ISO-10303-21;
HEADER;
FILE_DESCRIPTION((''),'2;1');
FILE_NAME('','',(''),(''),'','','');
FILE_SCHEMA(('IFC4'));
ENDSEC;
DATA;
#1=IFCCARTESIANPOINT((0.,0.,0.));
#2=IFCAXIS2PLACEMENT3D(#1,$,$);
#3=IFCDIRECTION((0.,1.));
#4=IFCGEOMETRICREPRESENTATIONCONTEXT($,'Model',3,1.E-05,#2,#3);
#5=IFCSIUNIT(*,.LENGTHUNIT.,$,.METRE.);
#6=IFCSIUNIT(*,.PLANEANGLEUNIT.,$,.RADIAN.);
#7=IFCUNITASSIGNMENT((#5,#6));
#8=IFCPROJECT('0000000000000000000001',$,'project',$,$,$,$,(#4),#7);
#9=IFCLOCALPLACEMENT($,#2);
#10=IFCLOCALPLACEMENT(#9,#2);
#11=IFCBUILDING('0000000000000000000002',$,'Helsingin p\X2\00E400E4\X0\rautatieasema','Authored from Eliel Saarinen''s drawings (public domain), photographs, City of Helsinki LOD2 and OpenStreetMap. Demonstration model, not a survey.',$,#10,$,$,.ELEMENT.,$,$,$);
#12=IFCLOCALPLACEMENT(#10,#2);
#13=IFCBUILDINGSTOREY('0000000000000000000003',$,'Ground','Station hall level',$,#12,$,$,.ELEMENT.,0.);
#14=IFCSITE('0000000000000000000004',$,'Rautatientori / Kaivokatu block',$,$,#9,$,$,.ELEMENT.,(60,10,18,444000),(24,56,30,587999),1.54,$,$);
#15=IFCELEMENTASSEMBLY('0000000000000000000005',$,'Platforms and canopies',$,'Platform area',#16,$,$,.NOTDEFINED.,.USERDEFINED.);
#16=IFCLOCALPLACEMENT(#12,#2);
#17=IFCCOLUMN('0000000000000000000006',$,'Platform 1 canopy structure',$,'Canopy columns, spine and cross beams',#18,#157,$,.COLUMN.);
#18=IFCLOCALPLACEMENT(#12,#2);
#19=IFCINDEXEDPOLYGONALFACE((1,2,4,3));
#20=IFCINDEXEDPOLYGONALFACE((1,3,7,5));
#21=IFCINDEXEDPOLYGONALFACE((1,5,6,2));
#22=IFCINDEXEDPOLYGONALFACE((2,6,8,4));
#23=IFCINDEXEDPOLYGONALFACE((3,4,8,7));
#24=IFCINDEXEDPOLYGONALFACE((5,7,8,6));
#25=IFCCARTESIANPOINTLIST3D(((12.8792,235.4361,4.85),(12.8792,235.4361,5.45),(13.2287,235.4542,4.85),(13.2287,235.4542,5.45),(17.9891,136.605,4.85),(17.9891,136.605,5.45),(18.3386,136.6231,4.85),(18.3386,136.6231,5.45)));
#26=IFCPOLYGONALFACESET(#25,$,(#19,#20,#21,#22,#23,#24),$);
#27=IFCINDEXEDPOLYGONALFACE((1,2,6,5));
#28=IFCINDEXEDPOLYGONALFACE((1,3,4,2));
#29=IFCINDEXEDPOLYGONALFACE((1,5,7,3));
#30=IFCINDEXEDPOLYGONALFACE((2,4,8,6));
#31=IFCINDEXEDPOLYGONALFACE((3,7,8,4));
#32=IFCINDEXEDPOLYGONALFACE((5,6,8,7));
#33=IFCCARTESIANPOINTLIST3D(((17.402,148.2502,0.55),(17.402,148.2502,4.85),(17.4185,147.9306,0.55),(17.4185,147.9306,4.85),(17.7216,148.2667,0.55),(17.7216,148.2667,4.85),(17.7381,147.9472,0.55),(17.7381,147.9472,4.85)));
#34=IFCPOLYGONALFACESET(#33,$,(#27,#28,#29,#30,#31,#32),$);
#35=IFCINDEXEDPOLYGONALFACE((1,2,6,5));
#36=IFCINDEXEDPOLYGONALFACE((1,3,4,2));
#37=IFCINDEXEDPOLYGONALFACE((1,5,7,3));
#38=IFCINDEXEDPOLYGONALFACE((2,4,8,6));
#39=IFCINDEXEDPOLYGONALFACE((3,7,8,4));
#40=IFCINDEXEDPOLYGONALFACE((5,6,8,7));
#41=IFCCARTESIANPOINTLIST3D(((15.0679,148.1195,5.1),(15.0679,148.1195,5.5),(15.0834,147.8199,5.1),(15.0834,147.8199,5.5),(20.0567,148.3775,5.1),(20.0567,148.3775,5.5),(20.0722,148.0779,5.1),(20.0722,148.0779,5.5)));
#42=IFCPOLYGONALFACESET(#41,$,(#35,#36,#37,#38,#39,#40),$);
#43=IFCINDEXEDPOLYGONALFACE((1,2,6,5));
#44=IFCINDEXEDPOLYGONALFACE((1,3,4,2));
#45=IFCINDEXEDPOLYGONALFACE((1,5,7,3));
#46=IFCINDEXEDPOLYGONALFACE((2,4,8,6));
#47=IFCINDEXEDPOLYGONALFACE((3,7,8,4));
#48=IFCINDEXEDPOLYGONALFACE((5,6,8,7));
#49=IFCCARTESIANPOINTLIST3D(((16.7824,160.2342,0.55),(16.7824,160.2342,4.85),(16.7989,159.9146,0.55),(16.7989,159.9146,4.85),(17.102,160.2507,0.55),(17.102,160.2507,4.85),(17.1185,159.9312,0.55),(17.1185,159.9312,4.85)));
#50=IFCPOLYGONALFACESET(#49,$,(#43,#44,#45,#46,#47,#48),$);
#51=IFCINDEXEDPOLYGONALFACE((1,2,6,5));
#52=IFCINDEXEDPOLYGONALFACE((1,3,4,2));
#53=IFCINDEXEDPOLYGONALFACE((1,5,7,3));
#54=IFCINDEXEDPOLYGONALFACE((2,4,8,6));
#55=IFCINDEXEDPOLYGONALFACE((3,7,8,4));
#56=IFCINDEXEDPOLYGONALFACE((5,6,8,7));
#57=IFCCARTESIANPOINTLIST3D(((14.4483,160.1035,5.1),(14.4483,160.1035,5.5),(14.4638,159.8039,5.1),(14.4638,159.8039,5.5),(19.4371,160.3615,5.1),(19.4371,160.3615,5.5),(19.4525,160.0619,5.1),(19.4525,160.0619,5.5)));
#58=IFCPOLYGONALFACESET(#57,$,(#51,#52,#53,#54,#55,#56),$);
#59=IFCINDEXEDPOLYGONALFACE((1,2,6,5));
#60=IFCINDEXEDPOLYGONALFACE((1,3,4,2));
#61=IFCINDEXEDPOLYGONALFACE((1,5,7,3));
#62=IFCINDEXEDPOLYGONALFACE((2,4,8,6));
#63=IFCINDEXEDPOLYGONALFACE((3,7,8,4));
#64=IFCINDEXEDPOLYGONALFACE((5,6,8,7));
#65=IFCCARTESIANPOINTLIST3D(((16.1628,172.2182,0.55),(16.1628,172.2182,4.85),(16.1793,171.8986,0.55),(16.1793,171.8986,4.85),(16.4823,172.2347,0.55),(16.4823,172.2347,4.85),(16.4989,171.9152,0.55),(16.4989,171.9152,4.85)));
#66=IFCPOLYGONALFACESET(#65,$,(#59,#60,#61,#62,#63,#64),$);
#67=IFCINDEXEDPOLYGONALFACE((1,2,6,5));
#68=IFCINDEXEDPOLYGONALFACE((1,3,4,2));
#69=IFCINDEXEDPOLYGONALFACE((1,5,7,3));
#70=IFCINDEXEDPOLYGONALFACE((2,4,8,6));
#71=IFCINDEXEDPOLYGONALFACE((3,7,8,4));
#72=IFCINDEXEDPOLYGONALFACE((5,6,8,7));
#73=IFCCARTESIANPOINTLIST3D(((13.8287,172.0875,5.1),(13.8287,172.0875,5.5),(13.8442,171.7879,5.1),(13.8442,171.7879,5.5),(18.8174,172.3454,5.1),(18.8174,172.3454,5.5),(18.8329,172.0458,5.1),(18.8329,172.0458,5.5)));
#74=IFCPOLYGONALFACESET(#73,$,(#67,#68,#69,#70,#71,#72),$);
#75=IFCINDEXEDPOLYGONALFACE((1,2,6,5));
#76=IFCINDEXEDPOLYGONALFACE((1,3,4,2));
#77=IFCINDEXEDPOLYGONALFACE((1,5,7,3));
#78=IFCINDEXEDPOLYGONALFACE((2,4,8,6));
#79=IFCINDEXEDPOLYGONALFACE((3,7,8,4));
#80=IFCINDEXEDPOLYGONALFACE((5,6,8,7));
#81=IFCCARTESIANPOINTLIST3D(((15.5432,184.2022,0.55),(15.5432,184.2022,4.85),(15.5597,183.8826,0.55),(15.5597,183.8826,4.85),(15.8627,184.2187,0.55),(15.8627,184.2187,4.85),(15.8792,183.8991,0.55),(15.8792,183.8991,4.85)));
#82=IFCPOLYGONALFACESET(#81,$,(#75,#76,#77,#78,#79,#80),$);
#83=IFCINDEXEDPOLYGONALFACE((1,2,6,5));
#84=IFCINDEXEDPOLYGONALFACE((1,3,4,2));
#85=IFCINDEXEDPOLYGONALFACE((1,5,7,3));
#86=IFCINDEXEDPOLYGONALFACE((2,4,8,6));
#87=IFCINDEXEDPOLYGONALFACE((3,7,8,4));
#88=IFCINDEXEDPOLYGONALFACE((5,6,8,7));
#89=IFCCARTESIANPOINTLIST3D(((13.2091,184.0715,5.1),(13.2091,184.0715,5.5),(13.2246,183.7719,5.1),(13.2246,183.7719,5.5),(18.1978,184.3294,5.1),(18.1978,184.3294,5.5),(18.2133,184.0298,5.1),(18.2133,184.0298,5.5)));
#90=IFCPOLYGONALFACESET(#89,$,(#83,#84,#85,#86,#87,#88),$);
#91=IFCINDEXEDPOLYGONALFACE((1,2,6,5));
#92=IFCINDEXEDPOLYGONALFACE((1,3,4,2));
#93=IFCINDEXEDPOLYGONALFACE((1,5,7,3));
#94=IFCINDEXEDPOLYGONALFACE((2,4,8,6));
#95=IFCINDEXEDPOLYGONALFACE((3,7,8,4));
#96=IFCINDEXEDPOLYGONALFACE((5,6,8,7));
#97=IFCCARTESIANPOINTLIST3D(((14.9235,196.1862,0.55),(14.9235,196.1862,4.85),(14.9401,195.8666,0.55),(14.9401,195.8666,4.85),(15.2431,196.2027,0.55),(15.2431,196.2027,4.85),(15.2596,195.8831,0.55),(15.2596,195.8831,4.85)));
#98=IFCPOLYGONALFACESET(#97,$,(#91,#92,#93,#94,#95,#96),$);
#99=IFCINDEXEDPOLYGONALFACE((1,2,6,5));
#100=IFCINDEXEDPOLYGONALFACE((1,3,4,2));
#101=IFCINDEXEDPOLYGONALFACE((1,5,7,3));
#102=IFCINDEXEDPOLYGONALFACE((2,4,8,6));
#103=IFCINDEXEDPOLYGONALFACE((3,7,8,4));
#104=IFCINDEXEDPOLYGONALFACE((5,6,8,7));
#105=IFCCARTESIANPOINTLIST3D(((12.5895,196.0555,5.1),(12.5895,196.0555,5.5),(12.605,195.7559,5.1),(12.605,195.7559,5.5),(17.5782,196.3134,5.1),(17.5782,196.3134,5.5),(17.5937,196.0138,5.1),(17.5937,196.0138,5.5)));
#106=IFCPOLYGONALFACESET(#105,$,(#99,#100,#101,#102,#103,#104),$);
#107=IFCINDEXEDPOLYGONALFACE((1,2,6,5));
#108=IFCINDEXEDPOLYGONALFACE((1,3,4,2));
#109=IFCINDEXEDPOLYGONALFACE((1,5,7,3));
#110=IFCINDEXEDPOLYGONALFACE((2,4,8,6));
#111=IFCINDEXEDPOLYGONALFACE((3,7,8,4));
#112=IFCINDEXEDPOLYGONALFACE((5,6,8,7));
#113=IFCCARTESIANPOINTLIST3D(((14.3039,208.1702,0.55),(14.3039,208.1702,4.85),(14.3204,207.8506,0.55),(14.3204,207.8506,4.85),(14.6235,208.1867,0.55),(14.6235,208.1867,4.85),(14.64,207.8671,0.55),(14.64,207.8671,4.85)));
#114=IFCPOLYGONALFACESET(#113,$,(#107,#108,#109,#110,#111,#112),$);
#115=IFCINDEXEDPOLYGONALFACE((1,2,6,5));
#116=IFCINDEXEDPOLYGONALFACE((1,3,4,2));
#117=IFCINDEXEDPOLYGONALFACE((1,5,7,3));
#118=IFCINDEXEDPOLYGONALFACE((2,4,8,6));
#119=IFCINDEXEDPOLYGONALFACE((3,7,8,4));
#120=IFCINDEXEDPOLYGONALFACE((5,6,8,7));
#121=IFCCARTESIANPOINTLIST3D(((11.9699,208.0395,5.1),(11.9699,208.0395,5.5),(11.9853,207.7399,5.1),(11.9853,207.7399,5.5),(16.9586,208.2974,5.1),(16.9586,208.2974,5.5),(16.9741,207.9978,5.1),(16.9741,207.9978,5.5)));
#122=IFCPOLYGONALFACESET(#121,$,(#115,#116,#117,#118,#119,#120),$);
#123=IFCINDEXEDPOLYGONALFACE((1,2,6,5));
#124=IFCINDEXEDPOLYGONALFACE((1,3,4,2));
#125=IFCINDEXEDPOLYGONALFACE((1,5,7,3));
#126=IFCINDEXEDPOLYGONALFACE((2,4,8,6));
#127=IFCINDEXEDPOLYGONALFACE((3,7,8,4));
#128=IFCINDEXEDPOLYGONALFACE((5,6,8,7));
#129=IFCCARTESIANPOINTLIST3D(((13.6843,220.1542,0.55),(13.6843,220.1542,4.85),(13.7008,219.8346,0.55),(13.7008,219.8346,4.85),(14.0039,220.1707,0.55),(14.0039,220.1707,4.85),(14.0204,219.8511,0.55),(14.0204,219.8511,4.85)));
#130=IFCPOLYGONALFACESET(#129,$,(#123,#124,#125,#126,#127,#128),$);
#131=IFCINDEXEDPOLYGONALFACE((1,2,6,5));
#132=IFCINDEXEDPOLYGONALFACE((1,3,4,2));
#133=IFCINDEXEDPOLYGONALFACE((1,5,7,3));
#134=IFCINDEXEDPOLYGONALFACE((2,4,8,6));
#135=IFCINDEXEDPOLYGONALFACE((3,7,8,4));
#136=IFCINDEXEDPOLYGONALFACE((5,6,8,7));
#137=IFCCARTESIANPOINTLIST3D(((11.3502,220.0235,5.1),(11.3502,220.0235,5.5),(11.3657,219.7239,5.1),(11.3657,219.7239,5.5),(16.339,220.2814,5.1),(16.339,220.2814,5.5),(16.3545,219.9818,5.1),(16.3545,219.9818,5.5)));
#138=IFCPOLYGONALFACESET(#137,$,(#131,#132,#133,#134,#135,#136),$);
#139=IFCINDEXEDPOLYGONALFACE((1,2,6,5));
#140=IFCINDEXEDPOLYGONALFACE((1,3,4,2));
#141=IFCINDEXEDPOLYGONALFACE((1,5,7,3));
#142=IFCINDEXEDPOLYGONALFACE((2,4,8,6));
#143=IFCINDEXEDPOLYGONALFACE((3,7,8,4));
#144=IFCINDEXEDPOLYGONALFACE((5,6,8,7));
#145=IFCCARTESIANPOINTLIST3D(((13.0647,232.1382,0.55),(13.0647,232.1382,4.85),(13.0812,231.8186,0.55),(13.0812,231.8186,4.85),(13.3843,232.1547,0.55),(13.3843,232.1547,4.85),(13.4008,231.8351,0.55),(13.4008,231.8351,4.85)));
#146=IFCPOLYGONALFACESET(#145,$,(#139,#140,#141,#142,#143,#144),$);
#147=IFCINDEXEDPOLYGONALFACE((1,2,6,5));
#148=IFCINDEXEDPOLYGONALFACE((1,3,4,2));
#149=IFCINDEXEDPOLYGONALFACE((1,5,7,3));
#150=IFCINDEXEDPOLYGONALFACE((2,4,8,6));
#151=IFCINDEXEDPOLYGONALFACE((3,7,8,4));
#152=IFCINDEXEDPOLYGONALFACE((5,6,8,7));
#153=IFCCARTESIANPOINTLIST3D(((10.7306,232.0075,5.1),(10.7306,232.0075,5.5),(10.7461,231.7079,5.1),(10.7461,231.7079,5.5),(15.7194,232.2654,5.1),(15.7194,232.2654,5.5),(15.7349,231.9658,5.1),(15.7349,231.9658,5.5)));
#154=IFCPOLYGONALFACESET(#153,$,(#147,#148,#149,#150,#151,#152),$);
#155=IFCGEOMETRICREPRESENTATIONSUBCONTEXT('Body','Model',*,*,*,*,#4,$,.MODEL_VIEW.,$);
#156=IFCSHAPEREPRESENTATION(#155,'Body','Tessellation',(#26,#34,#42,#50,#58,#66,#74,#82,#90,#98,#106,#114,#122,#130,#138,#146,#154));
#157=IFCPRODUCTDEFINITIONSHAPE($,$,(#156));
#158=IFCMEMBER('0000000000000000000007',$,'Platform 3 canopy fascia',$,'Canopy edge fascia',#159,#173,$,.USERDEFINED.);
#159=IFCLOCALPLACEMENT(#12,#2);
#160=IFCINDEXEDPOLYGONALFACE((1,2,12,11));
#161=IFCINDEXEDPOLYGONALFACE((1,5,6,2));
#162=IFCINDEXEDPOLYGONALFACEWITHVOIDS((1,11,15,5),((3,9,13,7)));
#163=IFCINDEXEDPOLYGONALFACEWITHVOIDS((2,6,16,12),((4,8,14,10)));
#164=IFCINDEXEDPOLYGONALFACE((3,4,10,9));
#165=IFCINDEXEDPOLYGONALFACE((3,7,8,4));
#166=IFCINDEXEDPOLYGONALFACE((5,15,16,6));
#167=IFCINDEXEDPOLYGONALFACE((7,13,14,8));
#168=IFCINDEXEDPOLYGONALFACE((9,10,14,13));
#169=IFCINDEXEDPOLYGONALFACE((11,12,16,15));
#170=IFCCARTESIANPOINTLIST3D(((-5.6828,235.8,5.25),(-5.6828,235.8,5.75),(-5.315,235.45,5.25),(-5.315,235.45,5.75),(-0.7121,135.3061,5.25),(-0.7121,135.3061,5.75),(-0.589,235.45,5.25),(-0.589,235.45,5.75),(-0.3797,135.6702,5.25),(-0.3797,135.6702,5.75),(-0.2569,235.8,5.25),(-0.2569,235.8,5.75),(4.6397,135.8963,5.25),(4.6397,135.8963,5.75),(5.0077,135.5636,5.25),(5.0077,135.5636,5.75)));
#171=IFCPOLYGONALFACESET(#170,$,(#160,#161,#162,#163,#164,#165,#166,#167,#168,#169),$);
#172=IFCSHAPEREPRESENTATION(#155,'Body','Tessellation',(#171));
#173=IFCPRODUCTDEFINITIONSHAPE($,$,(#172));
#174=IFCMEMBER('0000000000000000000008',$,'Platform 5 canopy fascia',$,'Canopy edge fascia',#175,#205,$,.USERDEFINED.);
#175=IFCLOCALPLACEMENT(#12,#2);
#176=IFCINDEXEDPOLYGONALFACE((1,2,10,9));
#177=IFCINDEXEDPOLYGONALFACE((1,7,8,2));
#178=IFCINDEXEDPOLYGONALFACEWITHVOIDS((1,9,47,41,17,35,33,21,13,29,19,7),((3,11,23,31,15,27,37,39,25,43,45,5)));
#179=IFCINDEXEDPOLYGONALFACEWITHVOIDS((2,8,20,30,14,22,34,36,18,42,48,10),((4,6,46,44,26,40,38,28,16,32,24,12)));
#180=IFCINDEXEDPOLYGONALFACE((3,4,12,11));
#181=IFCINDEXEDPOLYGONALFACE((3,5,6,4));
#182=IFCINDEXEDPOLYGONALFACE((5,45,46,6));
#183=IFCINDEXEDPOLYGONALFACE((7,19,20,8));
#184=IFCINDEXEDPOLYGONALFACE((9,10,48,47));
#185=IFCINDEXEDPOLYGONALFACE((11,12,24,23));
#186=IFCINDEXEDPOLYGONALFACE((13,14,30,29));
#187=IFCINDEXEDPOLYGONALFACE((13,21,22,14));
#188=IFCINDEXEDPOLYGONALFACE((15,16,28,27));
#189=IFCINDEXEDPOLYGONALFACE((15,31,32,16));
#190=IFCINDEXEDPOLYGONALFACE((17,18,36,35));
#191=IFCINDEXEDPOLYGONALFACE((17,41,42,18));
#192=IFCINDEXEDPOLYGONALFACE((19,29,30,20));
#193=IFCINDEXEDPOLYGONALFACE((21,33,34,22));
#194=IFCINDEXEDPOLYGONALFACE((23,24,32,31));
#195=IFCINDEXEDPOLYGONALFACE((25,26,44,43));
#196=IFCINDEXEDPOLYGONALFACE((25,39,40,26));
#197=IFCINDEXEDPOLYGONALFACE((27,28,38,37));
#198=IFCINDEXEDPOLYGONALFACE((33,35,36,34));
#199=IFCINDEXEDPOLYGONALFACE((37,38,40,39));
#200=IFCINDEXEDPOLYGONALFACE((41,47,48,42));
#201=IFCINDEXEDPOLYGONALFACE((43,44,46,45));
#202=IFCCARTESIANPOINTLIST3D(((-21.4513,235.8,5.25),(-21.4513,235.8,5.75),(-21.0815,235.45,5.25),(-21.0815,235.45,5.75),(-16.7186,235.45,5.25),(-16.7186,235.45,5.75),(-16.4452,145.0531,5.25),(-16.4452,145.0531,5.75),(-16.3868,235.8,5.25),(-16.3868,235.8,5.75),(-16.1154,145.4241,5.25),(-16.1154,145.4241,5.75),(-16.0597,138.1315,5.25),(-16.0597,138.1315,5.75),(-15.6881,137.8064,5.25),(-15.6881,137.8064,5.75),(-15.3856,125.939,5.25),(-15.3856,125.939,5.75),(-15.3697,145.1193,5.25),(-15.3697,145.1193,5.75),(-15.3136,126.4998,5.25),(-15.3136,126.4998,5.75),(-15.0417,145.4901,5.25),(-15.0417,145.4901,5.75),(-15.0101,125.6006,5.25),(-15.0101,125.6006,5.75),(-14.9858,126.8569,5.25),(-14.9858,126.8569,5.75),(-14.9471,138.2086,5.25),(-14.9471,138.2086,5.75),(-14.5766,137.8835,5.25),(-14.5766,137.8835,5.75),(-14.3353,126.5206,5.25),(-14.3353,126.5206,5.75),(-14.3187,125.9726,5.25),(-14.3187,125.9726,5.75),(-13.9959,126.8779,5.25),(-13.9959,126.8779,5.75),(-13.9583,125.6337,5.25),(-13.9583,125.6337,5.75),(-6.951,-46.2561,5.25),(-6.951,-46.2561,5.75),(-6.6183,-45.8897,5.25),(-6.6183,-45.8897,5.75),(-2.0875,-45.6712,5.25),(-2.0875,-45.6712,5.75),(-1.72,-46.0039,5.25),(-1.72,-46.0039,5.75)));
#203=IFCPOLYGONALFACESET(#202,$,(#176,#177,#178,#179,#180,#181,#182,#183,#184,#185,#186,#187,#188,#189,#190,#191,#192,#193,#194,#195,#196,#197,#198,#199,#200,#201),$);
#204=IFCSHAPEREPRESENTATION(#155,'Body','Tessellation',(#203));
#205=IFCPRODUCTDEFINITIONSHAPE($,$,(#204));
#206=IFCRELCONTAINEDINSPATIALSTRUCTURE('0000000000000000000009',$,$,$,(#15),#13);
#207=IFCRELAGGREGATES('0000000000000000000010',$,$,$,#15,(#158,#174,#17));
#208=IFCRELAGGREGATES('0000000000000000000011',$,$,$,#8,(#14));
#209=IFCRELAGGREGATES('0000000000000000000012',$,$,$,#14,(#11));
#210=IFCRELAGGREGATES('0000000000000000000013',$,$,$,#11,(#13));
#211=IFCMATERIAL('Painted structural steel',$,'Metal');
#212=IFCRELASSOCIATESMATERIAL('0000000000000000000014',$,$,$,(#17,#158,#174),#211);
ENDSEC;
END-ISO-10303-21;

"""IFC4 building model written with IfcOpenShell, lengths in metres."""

from ifc_helpers import new_model, si_unit, direction, frame, frame_2d, origin, place, context, subcontext, project, spatial, polyline, rectangle, outline, extrude, material, element, aggregate, save


model = new_model("IFC4")

# Units and contexts
model_context = context("Model", 3, precision=1e-05, world=origin(), true_north=direction((0.0, 1.0)))
body_context = subcontext(model_context, "Body", "Model", "MODEL_VIEW")
ifc_project = project(units=[si_unit("LENGTHUNIT", "METRE"), si_unit("PLANEANGLEUNIT", "RADIAN")], contexts=[model_context])

# Site, building, storey
site_placement = place(None, origin())
site = spatial("IfcSite", under=ifc_project, at=site_placement, Name="Rautatientori / Kaivokatu block", CompositionType="ELEMENT", RefLatitude=(60, 10, 18, 444000), RefLongitude=(24, 56, 30, 587999), RefElevation=1.54)
building_placement = place(site_placement, origin())
building = spatial("IfcBuilding", under=site, at=building_placement, Name="Helsingin päärautatieasema", Description="Authored from Eliel Saarinen's drawings (public domain), photographs, City of Helsinki LOD2 and OpenStreetMap. Demonstration model, not a survey.", CompositionType="ELEMENT")
storey_placement = place(building_placement, origin())
storey = spatial("IfcBuildingStorey", under=building, at=storey_placement, Name="Ground", Description="Station hall level", CompositionType="ELEMENT", Elevation=0.0)

# Element assembly, column, members
assembly_placement = place(building_placement, origin())
assembly = element("IfcElementAssembly", 1, at=assembly_placement, inside=storey, Name="Platforms and canopies", ObjectType="Platform area", AssemblyPlace="NOTDEFINED", PredefinedType="USERDEFINED")
ifc_material_1 = material(Name="Painted structural steel", Category="Metal")
column_1_placement = place(building_placement, origin())
column_1 = element("IfcColumn", 2, at=column_1_placement, material=ifc_material_1, Name="Platform 1 canopy structure", ObjectType="Canopy columns, spine and cross beams", PredefinedType="COLUMN", context=body_context, shape_type="SweptSolid", body=[
    extrude(rectangle(XDim=98.9631, YDim=0.35, at=frame_2d((0.0, 0.0), x_axis=(-0.051635, 0.998666))), frame((15.6089, 186.0296, 4.85)), (0.0, 0.0, 1.0), 0.6),
    extrude(rectangle(XDim=0.32, YDim=0.32, at=frame_2d((0.0, 0.0), x_axis=(-0.051635, 0.998666))), frame((17.57, 148.0987, 0.55)), (0.0, 0.0, 1.0), 4.3),
    extrude(rectangle(XDim=0.3, YDim=4.9954, at=frame_2d((0.0, 0.0), x_axis=(-0.051635, 0.998666))), frame((17.57, 148.0987, 5.1)), (0.0, 0.0, 1.0), 0.4),
    extrude(rectangle(XDim=0.32, YDim=0.32, at=frame_2d((0.0, 0.0), x_axis=(-0.051635, 0.998666))), frame((16.9504, 160.0827, 0.55)), (0.0, 0.0, 1.0), 4.3),
    extrude(rectangle(XDim=0.3, YDim=4.9954, at=frame_2d((0.0, 0.0), x_axis=(-0.051635, 0.998666))), frame((16.9504, 160.0827, 5.1)), (0.0, 0.0, 1.0), 0.4),
    extrude(rectangle(XDim=0.32, YDim=0.32, at=frame_2d((0.0, 0.0), x_axis=(-0.051635, 0.998666))), frame((16.3308, 172.0667, 0.55)), (0.0, 0.0, 1.0), 4.3),
    extrude(rectangle(XDim=0.3, YDim=4.9954, at=frame_2d((0.0, 0.0), x_axis=(-0.051635, 0.998666))), frame((16.3308, 172.0667, 5.1)), (0.0, 0.0, 1.0), 0.4),
    extrude(rectangle(XDim=0.32, YDim=0.32, at=frame_2d((0.0, 0.0), x_axis=(-0.051635, 0.998666))), frame((15.7112, 184.0507, 0.55)), (0.0, 0.0, 1.0), 4.3),
    extrude(rectangle(XDim=0.3, YDim=4.9954, at=frame_2d((0.0, 0.0), x_axis=(-0.051635, 0.998666))), frame((15.7112, 184.0507, 5.1)), (0.0, 0.0, 1.0), 0.4),
    extrude(rectangle(XDim=0.32, YDim=0.32, at=frame_2d((0.0, 0.0), x_axis=(-0.051635, 0.998666))), frame((15.0916, 196.0347, 0.55)), (0.0, 0.0, 1.0), 4.3),
    extrude(rectangle(XDim=0.3, YDim=4.9954, at=frame_2d((0.0, 0.0), x_axis=(-0.051635, 0.998666))), frame((15.0916, 196.0347, 5.1)), (0.0, 0.0, 1.0), 0.4),
    extrude(rectangle(XDim=0.32, YDim=0.32, at=frame_2d((0.0, 0.0), x_axis=(-0.051635, 0.998666))), frame((14.472, 208.0187, 0.55)), (0.0, 0.0, 1.0), 4.3),
    extrude(rectangle(XDim=0.3, YDim=4.9954, at=frame_2d((0.0, 0.0), x_axis=(-0.051635, 0.998666))), frame((14.472, 208.0187, 5.1)), (0.0, 0.0, 1.0), 0.4),
    extrude(rectangle(XDim=0.32, YDim=0.32, at=frame_2d((0.0, 0.0), x_axis=(-0.051635, 0.998666))), frame((13.8524, 220.0026, 0.55)), (0.0, 0.0, 1.0), 4.3),
    extrude(rectangle(XDim=0.3, YDim=4.9954, at=frame_2d((0.0, 0.0), x_axis=(-0.051635, 0.998666))), frame((13.8524, 220.0026, 5.1)), (0.0, 0.0, 1.0), 0.4),
    extrude(rectangle(XDim=0.32, YDim=0.32, at=frame_2d((0.0, 0.0), x_axis=(-0.051635, 0.998666))), frame((13.2327, 231.9866, 0.55)), (0.0, 0.0, 1.0), 4.3),
    extrude(rectangle(XDim=0.3, YDim=4.9954, at=frame_2d((0.0, 0.0), x_axis=(-0.051635, 0.998666))), frame((13.2327, 231.9866, 5.1)), (0.0, 0.0, 1.0), 0.4),
])
member_1_placement = place(building_placement, origin())
member_1 = element("IfcMember", 3, at=member_1_placement, material=ifc_material_1, Name="Platform 3 canopy fascia", ObjectType="Canopy edge fascia", PredefinedType="USERDEFINED", context=body_context, shape_type="SweptSolid", body=[
    extrude(outline(polyline([(-5.6828, 235.8), (-0.2569, 235.8), (5.0077, 135.5636), (-0.7121, 135.3061), (-5.6828, 235.8)]), holes=[polyline([(-5.315, 235.45), (-0.589, 235.45), (4.6397, 135.8963), (-0.3797, 135.6702), (-5.315, 235.45)])]), frame((0.0, 0.0, 5.25)), (0.0, 0.0, 1.0), 0.5),
])
member_2_placement = place(building_placement, origin())
member_2 = element("IfcMember", 4, at=member_2_placement, material=ifc_material_1, Name="Platform 5 canopy fascia", ObjectType="Canopy edge fascia", PredefinedType="USERDEFINED", context=body_context, shape_type="SweptSolid", body=[
    extrude(outline(polyline([(-16.4452, 145.0531), (-21.4513, 235.8), (-16.3868, 235.8), (-1.72, -46.0039), (-6.951, -46.2561), (-15.3856, 125.939), (-14.3187, 125.9726), (-14.3353, 126.5206), (-15.3136, 126.4998), (-16.0597, 138.1315), (-14.9471, 138.2086), (-15.3697, 145.1193), (-16.4452, 145.0531)]), holes=[polyline([(-16.1154, 145.4241), (-21.0815, 235.45), (-16.7186, 235.45), (-2.0875, -45.6712), (-6.6183, -45.8897), (-15.0101, 125.6006), (-13.9583, 125.6337), (-13.9959, 126.8779), (-14.9858, 126.8569), (-15.6881, 137.8064), (-14.5766, 137.8835), (-15.0417, 145.4901), (-16.1154, 145.4241)])]), frame((0.0, 0.0, 5.25)), (0.0, 0.0, 1.0), 0.5),
])
aggregate(assembly, [member_1, member_2, column_1])

save(model, "model.ifc")
